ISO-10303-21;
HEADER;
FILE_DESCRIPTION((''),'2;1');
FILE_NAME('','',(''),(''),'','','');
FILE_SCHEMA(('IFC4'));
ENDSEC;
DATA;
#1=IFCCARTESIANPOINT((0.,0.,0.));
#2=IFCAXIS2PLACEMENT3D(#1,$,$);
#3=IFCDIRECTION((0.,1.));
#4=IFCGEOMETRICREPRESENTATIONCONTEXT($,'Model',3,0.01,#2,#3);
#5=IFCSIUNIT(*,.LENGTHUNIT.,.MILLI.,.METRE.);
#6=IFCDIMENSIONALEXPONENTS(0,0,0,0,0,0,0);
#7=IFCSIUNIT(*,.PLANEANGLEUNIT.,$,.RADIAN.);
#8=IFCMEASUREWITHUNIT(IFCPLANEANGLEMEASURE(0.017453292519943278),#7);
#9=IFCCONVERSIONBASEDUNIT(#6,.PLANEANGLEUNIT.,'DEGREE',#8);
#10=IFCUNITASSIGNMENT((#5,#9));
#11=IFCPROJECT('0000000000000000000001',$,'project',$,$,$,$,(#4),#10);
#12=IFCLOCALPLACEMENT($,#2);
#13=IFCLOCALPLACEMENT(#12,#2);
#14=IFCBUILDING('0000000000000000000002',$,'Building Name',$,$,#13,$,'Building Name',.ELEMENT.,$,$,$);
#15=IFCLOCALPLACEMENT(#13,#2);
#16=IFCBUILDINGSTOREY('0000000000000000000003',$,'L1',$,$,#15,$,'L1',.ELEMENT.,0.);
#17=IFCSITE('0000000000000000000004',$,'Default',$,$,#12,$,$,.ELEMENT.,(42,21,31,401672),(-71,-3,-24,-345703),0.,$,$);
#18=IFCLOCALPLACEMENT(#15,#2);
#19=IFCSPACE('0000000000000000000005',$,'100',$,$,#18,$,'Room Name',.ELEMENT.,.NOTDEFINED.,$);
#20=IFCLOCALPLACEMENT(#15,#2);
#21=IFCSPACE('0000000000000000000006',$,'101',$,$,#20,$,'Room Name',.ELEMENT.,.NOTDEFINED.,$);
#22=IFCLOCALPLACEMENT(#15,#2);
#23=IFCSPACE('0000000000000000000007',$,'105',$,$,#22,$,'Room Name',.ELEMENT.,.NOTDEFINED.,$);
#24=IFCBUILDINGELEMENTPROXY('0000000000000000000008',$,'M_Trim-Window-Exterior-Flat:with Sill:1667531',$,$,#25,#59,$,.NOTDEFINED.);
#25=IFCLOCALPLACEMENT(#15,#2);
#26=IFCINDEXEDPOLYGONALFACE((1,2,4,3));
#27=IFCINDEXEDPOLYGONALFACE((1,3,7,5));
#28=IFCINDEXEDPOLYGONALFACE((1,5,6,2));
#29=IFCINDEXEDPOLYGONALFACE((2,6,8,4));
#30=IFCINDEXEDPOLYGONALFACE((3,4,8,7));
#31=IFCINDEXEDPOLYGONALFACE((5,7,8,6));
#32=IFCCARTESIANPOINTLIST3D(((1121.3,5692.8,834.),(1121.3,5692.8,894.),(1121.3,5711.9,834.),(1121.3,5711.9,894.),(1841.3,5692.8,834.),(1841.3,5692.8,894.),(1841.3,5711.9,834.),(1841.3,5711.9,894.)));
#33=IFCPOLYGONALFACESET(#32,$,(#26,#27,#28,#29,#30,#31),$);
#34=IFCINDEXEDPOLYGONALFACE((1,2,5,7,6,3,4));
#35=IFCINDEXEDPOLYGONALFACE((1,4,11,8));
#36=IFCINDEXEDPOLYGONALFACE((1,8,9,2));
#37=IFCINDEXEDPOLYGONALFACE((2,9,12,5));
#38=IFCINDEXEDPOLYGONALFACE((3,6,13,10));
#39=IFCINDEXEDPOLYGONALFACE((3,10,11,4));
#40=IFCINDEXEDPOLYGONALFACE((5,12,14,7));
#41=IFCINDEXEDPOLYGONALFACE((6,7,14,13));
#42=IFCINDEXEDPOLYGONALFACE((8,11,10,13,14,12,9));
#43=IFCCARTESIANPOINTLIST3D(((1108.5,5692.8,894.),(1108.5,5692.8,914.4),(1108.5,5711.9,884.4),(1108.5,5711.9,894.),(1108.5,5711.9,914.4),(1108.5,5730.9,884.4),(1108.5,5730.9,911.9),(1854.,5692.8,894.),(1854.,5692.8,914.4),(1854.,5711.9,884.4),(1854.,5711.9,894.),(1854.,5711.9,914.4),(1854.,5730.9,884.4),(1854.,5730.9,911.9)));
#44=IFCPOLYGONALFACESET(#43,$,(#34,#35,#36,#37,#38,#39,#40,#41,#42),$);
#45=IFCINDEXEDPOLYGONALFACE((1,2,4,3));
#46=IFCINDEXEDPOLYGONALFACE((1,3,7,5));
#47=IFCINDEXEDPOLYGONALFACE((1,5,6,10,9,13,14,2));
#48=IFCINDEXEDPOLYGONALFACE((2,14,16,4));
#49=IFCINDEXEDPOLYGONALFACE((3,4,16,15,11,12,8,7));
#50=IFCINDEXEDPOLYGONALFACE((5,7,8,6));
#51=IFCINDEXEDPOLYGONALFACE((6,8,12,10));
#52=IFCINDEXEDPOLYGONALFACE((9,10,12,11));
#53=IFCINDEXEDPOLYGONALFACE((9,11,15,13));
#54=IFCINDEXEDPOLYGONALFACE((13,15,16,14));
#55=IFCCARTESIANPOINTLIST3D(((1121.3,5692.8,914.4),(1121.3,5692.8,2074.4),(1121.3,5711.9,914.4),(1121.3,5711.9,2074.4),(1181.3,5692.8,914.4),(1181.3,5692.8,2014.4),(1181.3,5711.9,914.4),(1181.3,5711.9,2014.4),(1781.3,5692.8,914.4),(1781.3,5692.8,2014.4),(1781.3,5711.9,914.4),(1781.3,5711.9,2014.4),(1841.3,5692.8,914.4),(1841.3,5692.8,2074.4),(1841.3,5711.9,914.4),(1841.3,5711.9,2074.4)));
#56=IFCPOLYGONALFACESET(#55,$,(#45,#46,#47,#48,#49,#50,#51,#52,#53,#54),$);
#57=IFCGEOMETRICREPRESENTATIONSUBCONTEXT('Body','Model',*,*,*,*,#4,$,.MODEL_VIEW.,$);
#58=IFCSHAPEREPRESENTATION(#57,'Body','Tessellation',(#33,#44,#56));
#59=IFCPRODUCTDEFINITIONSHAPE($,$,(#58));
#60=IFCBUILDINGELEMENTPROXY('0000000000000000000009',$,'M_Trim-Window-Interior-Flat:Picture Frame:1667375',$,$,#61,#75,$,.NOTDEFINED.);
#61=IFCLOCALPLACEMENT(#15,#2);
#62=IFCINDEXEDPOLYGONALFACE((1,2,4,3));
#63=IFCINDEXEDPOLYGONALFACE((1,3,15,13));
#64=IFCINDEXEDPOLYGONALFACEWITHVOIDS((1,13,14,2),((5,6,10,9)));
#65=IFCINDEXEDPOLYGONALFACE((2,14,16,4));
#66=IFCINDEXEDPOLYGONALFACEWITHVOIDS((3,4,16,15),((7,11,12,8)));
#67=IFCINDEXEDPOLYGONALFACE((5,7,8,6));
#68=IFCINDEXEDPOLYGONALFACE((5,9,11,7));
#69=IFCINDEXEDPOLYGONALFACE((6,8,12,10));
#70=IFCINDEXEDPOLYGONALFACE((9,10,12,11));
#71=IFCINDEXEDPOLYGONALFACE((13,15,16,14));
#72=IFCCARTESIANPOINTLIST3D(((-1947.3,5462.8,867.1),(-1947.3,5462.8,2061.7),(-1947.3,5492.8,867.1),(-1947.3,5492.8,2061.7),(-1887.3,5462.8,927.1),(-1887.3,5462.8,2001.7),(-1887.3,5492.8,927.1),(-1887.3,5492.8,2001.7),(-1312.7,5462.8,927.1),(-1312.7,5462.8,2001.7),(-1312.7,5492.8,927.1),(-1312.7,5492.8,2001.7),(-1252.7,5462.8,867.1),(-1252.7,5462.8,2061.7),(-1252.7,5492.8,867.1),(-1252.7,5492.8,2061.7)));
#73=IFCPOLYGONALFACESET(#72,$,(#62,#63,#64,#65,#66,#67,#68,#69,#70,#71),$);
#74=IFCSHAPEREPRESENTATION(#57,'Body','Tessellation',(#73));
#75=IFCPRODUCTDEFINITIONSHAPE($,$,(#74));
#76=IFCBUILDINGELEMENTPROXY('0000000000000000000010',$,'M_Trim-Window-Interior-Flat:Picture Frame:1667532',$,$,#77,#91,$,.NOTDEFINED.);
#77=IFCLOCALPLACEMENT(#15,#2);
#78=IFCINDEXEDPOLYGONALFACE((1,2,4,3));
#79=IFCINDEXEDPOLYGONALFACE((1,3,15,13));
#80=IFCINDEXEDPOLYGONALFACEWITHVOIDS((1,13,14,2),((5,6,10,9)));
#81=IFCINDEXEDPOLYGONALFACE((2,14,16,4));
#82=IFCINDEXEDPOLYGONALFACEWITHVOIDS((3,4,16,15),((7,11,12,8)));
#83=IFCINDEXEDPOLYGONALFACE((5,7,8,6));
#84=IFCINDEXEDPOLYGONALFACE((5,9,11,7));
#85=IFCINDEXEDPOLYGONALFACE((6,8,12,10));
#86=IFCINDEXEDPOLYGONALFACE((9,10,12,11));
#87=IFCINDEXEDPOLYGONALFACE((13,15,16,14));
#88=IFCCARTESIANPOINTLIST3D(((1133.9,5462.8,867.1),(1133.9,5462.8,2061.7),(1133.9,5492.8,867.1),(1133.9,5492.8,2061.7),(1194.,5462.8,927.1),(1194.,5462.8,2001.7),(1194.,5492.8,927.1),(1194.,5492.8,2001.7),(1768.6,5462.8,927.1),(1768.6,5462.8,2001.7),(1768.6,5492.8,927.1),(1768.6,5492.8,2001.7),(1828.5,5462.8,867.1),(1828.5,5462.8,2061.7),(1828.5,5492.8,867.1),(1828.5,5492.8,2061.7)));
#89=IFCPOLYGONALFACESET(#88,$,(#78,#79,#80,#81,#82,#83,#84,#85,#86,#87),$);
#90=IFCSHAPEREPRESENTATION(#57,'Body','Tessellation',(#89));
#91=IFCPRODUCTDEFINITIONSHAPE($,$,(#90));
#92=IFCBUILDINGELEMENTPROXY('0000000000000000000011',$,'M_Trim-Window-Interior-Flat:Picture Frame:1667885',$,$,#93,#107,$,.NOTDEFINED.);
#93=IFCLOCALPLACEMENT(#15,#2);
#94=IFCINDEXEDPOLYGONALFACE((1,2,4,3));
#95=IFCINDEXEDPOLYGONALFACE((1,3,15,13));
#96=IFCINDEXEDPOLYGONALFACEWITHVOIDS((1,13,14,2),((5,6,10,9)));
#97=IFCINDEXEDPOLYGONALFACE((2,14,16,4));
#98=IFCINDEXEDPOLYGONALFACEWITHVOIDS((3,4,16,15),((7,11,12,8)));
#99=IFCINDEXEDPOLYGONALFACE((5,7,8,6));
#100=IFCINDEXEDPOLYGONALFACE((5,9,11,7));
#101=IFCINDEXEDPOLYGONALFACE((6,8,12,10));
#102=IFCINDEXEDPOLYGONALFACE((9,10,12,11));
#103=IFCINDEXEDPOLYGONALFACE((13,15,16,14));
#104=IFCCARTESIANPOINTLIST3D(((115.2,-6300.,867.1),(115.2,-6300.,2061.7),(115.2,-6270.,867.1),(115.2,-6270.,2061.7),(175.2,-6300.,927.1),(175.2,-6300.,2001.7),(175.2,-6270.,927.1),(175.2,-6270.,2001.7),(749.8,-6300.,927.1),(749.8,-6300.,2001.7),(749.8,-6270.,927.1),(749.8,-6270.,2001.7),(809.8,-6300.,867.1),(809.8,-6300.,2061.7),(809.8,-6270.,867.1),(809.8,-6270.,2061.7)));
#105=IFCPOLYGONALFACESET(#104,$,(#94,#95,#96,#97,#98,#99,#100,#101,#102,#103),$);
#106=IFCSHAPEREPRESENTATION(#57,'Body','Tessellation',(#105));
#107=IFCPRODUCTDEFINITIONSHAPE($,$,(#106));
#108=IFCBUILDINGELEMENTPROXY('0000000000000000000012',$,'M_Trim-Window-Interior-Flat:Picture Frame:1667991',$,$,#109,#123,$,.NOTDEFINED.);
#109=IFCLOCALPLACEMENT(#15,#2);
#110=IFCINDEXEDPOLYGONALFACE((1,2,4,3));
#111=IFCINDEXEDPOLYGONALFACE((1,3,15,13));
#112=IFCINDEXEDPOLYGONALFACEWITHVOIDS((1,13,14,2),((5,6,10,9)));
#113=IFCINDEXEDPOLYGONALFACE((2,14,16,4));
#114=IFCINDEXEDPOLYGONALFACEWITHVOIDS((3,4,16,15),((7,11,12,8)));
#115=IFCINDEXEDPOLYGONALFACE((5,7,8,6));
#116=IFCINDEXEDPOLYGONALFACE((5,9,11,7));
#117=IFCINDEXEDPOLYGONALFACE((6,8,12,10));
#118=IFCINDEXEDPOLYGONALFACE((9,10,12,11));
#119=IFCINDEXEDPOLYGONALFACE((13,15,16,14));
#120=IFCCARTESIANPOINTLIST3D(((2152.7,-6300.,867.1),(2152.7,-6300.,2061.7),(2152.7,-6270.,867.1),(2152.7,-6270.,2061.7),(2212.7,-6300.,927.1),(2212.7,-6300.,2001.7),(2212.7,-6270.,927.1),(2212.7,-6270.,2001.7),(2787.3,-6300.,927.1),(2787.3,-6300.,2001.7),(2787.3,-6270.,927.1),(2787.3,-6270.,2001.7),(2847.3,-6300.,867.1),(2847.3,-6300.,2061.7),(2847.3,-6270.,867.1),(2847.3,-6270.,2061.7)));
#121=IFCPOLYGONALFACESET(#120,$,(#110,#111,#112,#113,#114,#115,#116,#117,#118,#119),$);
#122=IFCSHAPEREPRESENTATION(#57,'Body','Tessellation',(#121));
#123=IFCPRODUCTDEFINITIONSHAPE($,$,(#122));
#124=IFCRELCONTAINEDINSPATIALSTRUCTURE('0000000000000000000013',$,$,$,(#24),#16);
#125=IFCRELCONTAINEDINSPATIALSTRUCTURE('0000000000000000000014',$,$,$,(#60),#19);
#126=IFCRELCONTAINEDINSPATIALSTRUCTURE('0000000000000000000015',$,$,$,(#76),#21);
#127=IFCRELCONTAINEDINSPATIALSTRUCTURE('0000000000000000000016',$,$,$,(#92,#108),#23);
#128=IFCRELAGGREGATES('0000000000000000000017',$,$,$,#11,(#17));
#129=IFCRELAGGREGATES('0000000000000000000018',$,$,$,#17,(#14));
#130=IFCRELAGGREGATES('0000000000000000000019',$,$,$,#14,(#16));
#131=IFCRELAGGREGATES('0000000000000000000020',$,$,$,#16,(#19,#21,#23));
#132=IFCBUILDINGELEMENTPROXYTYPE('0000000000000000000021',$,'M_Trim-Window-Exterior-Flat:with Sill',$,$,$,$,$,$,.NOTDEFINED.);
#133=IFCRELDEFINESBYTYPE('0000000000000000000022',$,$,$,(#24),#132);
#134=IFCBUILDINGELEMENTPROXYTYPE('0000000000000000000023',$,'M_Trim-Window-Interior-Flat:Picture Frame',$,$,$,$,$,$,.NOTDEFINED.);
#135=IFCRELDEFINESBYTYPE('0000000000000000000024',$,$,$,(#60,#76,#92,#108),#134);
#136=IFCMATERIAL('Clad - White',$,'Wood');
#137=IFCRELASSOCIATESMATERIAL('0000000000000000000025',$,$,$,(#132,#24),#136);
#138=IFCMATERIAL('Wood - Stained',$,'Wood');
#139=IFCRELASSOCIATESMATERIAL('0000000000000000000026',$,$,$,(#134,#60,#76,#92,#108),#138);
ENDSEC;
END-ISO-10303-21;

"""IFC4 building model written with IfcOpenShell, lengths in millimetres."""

from ifc_helpers import new_model, entity, si_unit, converted_unit, direction, frame, origin, place, context, subcontext, project, spatial, indexed_curve, outline, extrude, source, transform, mapped, material, type_object, type_shapes, element, save


model = new_model("IFC4")

# Units and contexts
model_context = context("Model", 3, precision=0.01, world=origin(), true_north=direction((0.0, 1.0)))
body_context = subcontext(model_context, "Body", "Model", "MODEL_VIEW")
ifc_project = project(units=[si_unit("LENGTHUNIT", "METRE", prefix="MILLI"), converted_unit("PLANEANGLEUNIT", "DEGREE", entity("IfcPlaneAngleMeasure", 0.017453292519943278), si_unit("PLANEANGLEUNIT", "RADIAN"), dimensions=[0, 0, 0, 0, 0, 0, 0])], contexts=[model_context])

# Site, building, storey
site_placement = place(None, origin())
site = spatial("IfcSite", under=ifc_project, at=site_placement, Name="Default", CompositionType="ELEMENT", RefLatitude=(42, 21, 31, 401672), RefLongitude=(-71, -3, -24, -345703), RefElevation=0.0)
building_placement = place(site_placement, origin())
building = spatial("IfcBuilding", under=site, at=building_placement, Name="Building Name", LongName="Building Name", CompositionType="ELEMENT")
storey_placement = place(building_placement, origin())
storey = spatial("IfcBuildingStorey", under=building, at=storey_placement, Name="L1", LongName="L1", CompositionType="ELEMENT", Elevation=0.0)

# Building element proxy
ifc_material_1 = material(Name="Clad - White", Category="Wood")
ifc_material_2 = material(Name="Wood - Stained", Category="Wood")
building_element_proxy_type_1 = type_object("IfcBuildingElementProxyType", Name="M_Trim-Window-Exterior-Flat:with Sill", PredefinedType="NOTDEFINED", material=ifc_material_1)
shared_shape_1 = source(origin(), body_context, "Body", "SweptSolid", [
    extrude(outline(indexed_curve([(-360.0, -30.0), (360.0, -30.0), (360.0, 30.0), (-360.0, 30.0), (-360.0, -30.0)], self_intersect=False)), frame((0.0, -1150.4, 0.0), z_axis=(0.0, 0.0, 1.0), x_axis=(-1.0, 0.0, 0.0)), (0.0, 0.0, 1.0), 19.0),
    extrude(outline(indexed_curve([(-19.0, -15.2), (0.0, -15.2), (0.0, -5.7), (19.0, -5.7), (19.0, 14.8), (0.0, 14.8), (-19.0, 12.3), (-19.0, -15.2)], self_intersect=False)), frame((-372.7, -1114.8, 19.0), z_axis=(1.0, 0.0, 0.0), x_axis=(0.0, 0.0, -1.0)), (0.0, 0.0, 1.0), 745.4),
    extrude(outline(indexed_curve([(-595.0, -360.0), (565.0, -360.0), (565.0, -300.0), (-535.0, -300.0), (-535.0, 300.0), (565.0, 300.0), (565.0, 360.0), (-595.0, 360.0), (-595.0, -360.0)], self_intersect=False)), frame((0.0, -535.0, 0.0), z_axis=(0.0, 0.0, 1.0), x_axis=(0.0, -1.0, 0.0)), (0.0, 0.0, 1.0), 19.0),
])
type_shapes(building_element_proxy_type_1, [shared_shape_1])
for number, where, z_axis, x_axis, name in (
    (1, (1481.3, 5692.8, 2014.4), (0.0, 1.0, 0.0), (-1.0, 0.0, 0.0), "M_Trim-Window-Exterior-Flat:with Sill:1667531"),
):
    element("IfcBuildingElementProxy", number, at=place(storey_placement, frame(where, z_axis=z_axis, x_axis=x_axis)), inside=storey, type_object=building_element_proxy_type_1, material=ifc_material_1, Name=name, PredefinedType="NOTDEFINED", context=body_context, shape_type="MappedRepresentation", body=[
        mapped(shared_shape_1, transform((0.0, 0.0, 0.0), scale=1.0)),
    ])

# Shared definitions
space_1_placement = place(storey_placement, origin())
space_1 = spatial("IfcSpace", under=storey, at=space_1_placement, Name="100", LongName="Room Name", CompositionType="ELEMENT", PredefinedType="NOTDEFINED")

# Building element proxy
building_element_proxy_type_2 = type_object("IfcBuildingElementProxyType", Name="M_Trim-Window-Interior-Flat:Picture Frame", PredefinedType="NOTDEFINED", material=ifc_material_2)
shared_shape_2 = source(origin(), body_context, "Body", "SweptSolid", [
    extrude(outline(indexed_curve([(-347.3, -597.3), (347.3, -597.3), (347.3, 597.3), (-347.3, 597.3), (-347.3, -597.3)], self_intersect=False), holes=[indexed_curve([(-287.3, -537.3), (-287.3, 537.3), (287.3, 537.3), (287.3, -537.3), (-287.3, -537.3)], self_intersect=False)]), frame((0.0, -550.0, 0.0), z_axis=(0.0, 0.0, 1.0), x_axis=(-1.0, 0.0, 0.0)), (0.0, 0.0, 1.0), 30.0),
])
type_shapes(building_element_proxy_type_2, [shared_shape_2])
proxy_1_placement = place(space_1_placement, frame((-1600.0, 5492.8, 2014.4), z_axis=(0.0, -1.0, 0.0), x_axis=(1.0, 0.0, 0.0)))
element("IfcBuildingElementProxy", 2, at=proxy_1_placement, inside=space_1, type_object=building_element_proxy_type_2, material=ifc_material_2, Name="M_Trim-Window-Interior-Flat:Picture Frame:1667375", PredefinedType="NOTDEFINED", context=body_context, shape_type="MappedRepresentation", body=[
    mapped(shared_shape_2, transform((0.0, 0.0, 0.0), scale=1.0)),
])

# Shared definitions
space_2_placement = place(storey_placement, origin())
space_2 = spatial("IfcSpace", under=storey, at=space_2_placement, Name="101", LongName="Room Name", CompositionType="ELEMENT", PredefinedType="NOTDEFINED")

# Building element proxy
proxy_2_placement = place(space_2_placement, frame((1481.2, 5492.8, 2014.4), z_axis=(0.0, -1.0, 0.0), x_axis=(1.0, 0.0, 0.0)))
element("IfcBuildingElementProxy", 3, at=proxy_2_placement, inside=space_2, type_object=building_element_proxy_type_2, material=ifc_material_2, Name="M_Trim-Window-Interior-Flat:Picture Frame:1667532", PredefinedType="NOTDEFINED", context=body_context, shape_type="MappedRepresentation", body=[
    mapped(shared_shape_2, transform((0.0, 0.0, 0.0), scale=1.0)),
])

# Shared definitions
space_3_placement = place(storey_placement, origin())
space_3 = spatial("IfcSpace", under=storey, at=space_3_placement, Name="105", LongName="Room Name", CompositionType="ELEMENT", PredefinedType="NOTDEFINED")

# Building element proxies
for number, where, z_axis, x_axis, name in (
    (4, (462.5, -6300.0, 2014.4), (0.0, 1.0, 0.0), (-1.0, 0.0, 0.0), "M_Trim-Window-Interior-Flat:Picture Frame:1667885"),
    (5, (2500.0, -6300.0, 2014.4), (0.0, 1.0, 0.0), (-1.0, 0.0, 0.0), "M_Trim-Window-Interior-Flat:Picture Frame:1667991"),
):
    element("IfcBuildingElementProxy", number, at=place(space_3_placement, frame(where, z_axis=z_axis, x_axis=x_axis)), inside=space_3, type_object=building_element_proxy_type_2, material=ifc_material_2, Name=name, PredefinedType="NOTDEFINED", context=body_context, shape_type="MappedRepresentation", body=[
        mapped(shared_shape_2, transform((0.0, 0.0, 0.0), scale=1.0)),
    ])

save(model, "model.ifc")
